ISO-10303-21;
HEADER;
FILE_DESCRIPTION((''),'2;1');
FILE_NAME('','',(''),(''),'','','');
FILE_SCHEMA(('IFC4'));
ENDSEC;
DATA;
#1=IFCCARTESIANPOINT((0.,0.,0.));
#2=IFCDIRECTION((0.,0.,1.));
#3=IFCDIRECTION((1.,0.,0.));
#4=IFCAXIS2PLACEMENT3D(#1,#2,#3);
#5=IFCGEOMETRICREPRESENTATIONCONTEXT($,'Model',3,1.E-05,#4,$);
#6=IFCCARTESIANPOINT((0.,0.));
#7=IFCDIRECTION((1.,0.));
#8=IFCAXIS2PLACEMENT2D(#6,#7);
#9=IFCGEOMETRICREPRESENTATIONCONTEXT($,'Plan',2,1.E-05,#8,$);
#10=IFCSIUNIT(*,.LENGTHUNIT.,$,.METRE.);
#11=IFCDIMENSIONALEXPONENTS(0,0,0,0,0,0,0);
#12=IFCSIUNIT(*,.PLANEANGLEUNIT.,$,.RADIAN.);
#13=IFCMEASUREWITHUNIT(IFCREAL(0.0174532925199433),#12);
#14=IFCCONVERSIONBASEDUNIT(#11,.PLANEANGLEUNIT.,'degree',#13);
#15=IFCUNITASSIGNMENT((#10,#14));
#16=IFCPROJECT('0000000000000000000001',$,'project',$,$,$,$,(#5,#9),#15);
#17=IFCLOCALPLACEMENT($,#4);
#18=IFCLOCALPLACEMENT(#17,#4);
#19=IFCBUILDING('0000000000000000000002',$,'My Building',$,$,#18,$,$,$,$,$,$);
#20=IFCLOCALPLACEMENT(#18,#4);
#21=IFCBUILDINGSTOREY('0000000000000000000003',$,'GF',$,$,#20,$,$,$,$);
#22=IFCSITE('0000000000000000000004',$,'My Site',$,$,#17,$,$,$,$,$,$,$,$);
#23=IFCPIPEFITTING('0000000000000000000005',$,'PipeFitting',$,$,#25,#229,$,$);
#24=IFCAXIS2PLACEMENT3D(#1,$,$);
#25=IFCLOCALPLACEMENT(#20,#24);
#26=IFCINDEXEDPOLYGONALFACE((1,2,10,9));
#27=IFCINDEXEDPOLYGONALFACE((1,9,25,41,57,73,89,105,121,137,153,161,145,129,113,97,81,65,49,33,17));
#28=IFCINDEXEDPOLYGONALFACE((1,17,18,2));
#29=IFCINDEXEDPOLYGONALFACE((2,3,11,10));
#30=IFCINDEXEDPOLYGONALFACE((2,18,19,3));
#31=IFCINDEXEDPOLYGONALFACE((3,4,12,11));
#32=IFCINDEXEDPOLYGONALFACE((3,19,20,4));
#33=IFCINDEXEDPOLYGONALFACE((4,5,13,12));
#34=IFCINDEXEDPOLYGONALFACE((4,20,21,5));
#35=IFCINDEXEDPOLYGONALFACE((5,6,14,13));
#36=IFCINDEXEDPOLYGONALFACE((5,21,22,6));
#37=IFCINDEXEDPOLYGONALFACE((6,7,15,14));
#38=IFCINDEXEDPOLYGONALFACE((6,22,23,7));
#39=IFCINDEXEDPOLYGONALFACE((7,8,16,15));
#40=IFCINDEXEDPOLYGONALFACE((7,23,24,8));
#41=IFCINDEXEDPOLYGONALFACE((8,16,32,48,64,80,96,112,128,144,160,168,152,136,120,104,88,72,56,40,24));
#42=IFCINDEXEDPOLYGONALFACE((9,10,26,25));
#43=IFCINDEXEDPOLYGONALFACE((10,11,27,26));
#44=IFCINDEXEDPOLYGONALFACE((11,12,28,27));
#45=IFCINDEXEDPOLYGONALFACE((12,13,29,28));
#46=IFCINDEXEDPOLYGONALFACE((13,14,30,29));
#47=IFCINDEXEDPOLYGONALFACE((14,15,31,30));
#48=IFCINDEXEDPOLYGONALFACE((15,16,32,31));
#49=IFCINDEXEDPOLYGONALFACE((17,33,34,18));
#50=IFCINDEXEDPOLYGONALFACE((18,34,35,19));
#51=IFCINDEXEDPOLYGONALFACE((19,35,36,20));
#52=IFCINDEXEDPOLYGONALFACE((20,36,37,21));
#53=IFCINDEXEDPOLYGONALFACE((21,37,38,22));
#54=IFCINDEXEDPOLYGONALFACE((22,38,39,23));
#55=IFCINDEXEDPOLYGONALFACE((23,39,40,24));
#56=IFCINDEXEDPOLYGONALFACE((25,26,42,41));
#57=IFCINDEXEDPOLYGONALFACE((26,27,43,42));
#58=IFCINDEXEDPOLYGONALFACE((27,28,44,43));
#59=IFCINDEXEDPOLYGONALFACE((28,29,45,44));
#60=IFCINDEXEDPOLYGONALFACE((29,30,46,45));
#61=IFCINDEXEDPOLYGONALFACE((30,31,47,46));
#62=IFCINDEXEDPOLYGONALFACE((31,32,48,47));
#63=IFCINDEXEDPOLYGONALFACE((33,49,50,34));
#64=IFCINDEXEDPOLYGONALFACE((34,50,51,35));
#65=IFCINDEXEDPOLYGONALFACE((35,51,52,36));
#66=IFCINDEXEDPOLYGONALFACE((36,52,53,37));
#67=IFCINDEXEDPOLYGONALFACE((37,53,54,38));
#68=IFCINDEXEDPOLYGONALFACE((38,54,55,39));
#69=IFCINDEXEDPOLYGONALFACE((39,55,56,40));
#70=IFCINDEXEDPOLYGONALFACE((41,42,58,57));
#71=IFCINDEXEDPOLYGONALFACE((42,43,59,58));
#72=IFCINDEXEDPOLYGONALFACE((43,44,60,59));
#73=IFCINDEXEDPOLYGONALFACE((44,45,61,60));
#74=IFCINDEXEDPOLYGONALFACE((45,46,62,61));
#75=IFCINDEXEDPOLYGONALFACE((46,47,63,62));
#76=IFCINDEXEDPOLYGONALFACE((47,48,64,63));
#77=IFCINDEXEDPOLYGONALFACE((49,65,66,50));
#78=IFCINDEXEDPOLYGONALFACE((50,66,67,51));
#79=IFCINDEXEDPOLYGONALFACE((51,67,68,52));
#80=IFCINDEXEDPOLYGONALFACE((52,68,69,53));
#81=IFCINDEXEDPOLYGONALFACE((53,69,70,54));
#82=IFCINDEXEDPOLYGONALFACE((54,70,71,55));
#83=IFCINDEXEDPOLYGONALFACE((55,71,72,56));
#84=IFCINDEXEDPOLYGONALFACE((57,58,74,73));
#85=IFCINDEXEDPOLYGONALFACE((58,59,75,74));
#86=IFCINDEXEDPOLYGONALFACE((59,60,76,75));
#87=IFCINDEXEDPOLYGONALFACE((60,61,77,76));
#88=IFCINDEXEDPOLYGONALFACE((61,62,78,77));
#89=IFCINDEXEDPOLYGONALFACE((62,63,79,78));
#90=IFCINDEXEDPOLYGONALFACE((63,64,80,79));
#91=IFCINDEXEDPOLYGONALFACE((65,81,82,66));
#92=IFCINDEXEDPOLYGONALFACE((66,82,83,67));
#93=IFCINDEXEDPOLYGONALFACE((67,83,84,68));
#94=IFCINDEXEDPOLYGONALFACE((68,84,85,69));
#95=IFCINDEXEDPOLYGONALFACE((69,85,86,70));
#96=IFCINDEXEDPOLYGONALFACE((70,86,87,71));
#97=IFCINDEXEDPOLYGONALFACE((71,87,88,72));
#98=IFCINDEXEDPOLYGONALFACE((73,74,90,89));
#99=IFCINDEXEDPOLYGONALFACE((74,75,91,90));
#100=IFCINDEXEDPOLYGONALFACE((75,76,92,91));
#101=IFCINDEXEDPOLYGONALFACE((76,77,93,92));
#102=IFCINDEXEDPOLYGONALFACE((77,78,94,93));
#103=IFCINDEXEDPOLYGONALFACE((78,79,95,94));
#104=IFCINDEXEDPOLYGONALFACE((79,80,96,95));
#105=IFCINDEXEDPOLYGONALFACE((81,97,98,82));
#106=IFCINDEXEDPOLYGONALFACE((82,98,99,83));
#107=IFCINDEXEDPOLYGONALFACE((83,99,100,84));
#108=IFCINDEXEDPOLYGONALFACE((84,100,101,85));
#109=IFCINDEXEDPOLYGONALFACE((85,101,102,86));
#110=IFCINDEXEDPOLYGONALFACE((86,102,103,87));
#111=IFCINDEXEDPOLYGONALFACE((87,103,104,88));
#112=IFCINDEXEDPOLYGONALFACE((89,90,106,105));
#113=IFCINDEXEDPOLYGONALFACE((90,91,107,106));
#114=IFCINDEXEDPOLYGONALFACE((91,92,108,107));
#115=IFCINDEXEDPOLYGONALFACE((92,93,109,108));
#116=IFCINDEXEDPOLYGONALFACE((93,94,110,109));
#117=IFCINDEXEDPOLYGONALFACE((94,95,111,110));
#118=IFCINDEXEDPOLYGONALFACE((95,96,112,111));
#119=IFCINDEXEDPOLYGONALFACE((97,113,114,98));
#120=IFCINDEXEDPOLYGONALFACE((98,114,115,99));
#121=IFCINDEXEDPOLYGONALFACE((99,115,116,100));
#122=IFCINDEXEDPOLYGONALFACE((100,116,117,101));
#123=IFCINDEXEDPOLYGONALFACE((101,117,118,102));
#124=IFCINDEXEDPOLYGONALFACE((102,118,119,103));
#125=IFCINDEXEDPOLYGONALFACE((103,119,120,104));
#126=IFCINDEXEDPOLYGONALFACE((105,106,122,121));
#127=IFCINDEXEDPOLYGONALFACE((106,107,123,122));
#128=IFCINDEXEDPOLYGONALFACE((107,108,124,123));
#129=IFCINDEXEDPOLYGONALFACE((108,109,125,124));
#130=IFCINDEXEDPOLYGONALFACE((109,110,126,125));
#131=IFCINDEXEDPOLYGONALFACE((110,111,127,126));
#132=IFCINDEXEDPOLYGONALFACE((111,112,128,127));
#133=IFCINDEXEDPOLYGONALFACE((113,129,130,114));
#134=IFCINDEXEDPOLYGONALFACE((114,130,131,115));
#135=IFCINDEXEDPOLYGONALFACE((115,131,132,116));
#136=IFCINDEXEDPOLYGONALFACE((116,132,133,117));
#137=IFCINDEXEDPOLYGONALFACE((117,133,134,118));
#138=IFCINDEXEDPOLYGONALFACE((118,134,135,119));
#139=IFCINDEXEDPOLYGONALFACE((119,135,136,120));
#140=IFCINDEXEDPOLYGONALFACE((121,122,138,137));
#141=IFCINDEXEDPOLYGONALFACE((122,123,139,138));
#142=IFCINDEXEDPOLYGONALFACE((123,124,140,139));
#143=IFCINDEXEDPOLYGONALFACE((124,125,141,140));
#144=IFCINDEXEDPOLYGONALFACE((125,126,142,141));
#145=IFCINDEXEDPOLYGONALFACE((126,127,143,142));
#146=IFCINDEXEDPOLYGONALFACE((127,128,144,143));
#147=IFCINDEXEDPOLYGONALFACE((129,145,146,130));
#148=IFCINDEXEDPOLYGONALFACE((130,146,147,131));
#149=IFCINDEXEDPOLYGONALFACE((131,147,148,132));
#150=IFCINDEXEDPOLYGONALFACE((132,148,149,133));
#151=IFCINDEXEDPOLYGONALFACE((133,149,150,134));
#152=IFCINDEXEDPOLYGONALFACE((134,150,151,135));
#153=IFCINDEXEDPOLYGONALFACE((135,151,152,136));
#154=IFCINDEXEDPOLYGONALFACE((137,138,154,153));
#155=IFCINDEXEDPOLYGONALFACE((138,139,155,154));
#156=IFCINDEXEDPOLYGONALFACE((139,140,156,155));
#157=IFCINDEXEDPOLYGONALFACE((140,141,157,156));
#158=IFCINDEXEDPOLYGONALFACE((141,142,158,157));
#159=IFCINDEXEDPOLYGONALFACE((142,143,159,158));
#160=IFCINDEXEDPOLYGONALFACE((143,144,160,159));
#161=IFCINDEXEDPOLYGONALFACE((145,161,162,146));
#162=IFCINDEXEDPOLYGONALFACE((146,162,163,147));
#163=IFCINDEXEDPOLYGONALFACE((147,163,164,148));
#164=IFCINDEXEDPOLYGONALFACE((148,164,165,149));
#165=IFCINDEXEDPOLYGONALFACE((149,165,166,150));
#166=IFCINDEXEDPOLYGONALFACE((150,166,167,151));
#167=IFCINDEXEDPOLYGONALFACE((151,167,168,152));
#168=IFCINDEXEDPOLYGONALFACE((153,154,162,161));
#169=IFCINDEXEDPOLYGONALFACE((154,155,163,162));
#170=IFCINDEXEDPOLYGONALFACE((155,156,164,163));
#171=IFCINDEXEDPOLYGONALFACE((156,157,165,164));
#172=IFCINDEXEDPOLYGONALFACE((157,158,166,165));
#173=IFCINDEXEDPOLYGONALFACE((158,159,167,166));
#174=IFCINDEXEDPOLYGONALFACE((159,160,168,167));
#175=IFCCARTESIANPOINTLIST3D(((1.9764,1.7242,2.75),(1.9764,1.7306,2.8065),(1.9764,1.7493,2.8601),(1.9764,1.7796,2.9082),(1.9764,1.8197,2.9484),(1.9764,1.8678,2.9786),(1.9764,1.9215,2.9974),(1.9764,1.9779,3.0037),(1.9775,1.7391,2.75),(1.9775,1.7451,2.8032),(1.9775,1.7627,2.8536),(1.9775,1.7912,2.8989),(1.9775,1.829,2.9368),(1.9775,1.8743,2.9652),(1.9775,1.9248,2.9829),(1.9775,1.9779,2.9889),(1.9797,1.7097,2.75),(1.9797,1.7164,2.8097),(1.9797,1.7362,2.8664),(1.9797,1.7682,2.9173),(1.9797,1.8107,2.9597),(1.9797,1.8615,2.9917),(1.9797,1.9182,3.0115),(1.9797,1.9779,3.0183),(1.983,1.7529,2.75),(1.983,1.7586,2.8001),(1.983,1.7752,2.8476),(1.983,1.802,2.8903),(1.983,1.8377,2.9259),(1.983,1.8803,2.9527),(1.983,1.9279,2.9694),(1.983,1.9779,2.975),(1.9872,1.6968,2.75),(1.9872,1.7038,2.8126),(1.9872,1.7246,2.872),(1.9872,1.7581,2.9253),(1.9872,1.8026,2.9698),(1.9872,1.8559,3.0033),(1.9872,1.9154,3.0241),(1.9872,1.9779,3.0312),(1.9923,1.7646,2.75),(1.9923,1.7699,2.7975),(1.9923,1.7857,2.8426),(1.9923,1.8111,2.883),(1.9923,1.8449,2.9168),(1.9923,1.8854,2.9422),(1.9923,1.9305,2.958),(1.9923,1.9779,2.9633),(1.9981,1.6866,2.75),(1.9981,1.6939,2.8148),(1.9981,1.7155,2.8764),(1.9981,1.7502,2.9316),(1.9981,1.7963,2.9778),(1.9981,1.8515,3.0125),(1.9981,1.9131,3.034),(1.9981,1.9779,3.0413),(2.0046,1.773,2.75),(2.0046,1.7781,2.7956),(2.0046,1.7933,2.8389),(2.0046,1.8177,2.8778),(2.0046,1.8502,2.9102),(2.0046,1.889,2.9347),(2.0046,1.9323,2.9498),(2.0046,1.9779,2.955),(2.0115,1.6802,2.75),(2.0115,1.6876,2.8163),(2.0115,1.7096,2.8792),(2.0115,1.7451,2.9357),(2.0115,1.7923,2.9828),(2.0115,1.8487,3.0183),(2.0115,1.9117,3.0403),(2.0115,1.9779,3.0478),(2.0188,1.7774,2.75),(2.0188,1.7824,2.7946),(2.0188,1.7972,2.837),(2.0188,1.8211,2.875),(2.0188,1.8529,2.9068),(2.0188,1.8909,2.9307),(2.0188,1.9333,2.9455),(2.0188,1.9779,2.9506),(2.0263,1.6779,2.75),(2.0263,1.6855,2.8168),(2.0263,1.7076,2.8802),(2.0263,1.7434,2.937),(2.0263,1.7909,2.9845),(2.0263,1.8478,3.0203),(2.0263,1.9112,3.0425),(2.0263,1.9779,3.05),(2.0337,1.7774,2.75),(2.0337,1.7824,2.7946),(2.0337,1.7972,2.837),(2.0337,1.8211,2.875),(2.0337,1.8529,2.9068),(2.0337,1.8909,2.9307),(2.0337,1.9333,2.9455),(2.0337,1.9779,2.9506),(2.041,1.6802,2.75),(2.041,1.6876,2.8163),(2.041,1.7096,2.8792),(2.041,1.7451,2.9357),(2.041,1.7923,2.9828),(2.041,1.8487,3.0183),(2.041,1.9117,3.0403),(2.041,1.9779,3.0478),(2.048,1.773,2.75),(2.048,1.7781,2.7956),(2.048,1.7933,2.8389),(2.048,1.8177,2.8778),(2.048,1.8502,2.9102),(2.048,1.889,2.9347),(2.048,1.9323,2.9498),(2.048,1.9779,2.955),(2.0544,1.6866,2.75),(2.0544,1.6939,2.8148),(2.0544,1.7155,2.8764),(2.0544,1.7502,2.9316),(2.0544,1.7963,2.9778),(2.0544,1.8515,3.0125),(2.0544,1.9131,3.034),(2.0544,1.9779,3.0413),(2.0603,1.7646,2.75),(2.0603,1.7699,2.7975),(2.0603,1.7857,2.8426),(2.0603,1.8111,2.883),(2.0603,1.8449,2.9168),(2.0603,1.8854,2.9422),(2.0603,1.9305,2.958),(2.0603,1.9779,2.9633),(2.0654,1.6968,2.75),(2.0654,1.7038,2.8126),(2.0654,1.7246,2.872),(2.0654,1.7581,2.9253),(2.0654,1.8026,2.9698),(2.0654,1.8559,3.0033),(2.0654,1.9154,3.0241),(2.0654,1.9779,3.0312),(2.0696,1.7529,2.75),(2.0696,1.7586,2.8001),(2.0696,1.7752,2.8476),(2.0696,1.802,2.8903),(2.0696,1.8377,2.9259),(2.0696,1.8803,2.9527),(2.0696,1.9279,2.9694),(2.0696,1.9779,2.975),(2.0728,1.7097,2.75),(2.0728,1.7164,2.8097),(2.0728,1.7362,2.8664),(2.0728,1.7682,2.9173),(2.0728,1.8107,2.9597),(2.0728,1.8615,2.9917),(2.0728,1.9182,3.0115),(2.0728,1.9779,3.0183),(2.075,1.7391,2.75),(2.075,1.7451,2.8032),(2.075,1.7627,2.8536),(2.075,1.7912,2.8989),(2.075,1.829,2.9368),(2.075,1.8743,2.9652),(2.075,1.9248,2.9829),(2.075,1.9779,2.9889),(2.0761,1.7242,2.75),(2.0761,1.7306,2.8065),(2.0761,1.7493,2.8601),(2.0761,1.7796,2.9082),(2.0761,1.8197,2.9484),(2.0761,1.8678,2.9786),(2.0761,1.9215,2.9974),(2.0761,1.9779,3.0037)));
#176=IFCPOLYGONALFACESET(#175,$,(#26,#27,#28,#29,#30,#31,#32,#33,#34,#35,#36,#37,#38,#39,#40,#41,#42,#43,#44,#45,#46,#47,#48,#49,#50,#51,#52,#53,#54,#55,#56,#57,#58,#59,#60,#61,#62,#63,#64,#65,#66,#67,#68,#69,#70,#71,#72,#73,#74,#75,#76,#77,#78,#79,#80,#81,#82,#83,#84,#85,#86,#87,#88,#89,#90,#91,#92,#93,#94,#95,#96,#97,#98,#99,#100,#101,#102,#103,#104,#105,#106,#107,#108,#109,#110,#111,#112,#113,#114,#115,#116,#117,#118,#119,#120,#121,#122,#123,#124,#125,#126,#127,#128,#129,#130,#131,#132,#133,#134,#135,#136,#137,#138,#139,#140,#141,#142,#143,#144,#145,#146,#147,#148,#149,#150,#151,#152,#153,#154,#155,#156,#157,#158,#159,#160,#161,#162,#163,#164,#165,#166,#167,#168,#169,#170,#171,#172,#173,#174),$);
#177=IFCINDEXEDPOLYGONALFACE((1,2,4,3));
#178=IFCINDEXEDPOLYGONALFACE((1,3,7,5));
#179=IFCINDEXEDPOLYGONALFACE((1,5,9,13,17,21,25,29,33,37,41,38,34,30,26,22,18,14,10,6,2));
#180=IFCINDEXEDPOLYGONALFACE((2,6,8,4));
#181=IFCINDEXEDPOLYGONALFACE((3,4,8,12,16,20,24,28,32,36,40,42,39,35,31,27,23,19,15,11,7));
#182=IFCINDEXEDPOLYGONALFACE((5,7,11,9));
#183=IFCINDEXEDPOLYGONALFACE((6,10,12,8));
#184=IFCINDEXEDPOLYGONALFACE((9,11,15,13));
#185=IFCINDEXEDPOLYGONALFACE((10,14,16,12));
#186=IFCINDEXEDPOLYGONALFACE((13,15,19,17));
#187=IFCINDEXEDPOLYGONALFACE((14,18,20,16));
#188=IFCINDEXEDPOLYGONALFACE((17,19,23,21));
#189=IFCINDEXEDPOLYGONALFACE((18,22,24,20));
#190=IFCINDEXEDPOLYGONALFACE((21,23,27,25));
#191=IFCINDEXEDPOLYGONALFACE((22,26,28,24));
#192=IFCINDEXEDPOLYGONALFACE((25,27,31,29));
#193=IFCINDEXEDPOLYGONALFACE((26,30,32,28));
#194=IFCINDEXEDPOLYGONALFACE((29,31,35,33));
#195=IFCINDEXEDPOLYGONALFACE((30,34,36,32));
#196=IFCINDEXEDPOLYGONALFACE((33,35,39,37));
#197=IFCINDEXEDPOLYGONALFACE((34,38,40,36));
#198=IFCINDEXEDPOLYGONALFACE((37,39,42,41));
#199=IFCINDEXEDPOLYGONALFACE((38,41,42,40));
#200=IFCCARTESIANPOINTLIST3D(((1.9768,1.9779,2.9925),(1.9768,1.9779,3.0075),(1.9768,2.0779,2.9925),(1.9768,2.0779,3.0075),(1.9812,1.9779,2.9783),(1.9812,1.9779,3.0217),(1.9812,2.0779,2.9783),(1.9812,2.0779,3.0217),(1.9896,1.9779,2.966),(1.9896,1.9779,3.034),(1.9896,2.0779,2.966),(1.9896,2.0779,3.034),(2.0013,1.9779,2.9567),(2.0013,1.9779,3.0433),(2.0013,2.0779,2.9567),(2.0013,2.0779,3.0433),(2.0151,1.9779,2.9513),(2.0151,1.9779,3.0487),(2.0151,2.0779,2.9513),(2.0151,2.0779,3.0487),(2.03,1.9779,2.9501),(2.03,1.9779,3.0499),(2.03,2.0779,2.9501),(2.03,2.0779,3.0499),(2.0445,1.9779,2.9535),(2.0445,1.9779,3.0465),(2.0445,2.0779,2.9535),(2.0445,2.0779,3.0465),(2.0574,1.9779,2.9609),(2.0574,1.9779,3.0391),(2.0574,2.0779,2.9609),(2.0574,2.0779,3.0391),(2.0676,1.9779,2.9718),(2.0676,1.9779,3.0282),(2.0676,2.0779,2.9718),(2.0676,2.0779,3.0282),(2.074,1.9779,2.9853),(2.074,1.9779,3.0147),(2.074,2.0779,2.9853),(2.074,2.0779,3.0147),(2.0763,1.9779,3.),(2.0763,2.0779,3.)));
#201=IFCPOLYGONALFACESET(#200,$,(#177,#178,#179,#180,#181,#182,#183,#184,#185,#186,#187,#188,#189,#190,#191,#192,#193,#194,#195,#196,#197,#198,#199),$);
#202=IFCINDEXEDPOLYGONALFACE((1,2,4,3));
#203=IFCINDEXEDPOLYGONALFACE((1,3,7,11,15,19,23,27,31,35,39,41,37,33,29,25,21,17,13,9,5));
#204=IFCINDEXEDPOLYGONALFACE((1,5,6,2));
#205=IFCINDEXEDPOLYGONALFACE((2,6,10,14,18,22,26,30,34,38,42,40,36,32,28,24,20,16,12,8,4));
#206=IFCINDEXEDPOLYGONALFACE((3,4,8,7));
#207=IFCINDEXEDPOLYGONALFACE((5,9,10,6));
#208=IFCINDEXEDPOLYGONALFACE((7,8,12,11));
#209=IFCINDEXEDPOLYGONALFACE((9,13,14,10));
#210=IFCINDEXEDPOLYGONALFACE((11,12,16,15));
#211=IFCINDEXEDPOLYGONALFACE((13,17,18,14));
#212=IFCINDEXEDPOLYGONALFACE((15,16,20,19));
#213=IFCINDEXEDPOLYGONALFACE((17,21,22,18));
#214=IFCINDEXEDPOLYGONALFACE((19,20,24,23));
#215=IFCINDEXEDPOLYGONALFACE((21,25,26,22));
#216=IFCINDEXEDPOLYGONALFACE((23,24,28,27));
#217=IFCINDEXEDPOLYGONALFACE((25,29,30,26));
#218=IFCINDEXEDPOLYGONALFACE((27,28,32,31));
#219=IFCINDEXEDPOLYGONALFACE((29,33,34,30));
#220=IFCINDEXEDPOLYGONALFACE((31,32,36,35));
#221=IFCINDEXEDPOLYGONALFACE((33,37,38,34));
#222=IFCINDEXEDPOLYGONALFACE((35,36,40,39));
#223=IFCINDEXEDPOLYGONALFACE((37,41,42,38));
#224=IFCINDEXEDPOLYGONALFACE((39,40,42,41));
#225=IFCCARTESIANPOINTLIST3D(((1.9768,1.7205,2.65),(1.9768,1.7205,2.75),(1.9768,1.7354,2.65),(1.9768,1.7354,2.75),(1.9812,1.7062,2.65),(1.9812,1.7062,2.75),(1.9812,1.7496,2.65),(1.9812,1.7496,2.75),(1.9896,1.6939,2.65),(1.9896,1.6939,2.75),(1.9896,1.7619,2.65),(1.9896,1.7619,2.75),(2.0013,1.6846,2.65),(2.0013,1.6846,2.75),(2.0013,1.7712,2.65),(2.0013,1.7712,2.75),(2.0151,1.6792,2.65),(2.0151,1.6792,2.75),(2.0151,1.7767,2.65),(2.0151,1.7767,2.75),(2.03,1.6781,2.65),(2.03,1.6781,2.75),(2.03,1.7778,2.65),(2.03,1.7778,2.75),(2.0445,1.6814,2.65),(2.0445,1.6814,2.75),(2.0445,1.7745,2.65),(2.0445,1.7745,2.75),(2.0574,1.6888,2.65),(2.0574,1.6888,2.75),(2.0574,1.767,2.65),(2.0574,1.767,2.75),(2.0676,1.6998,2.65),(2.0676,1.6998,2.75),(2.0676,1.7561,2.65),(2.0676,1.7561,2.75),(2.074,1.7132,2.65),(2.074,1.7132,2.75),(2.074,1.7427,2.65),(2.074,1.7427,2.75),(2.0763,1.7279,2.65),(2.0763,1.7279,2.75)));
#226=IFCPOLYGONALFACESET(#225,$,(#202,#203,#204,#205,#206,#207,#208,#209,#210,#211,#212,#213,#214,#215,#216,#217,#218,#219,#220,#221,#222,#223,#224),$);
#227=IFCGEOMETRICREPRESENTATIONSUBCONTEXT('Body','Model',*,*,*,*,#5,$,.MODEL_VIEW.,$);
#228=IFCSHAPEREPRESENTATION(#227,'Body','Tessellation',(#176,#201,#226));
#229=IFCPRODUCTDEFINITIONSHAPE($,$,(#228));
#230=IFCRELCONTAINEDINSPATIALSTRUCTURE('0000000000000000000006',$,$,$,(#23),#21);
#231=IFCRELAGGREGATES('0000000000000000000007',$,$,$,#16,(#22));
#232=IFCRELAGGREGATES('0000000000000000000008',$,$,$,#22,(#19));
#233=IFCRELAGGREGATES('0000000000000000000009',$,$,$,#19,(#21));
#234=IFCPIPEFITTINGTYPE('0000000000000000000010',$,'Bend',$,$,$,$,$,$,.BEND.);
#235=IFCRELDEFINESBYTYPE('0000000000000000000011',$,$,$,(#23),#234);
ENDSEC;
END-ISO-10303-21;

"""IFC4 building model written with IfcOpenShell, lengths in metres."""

from ifc_helpers import new_model, entity, si_unit, converted_unit, frame, origin_with_axes, origin_2d_with_axis, place, context, subcontext, project, spatial, circle, extrude, source, transform, mapped, type_object, type_shapes, element, save


model = new_model("IFC4")

# Units and contexts
model_context = context("Model", 3, precision=1e-05, world=origin_with_axes())
plan_context = context("Plan", 2, precision=1e-05, world=origin_2d_with_axis())
body_context_1 = subcontext(model_context, "Body", "Model", "MODEL_VIEW")
ifc_project = project(units=[si_unit("LENGTHUNIT", "METRE"), converted_unit("PLANEANGLEUNIT", "degree", entity("IfcReal", 0.0174532925199433), si_unit("PLANEANGLEUNIT", "RADIAN"), dimensions=[0, 0, 0, 0, 0, 0, 0])], contexts=[model_context, plan_context])

# Site, building, storey
site_placement = place(None, origin_with_axes())
site = spatial("IfcSite", under=ifc_project, at=site_placement, Name="My Site")
building_placement = place(site_placement, origin_with_axes())
building = spatial("IfcBuilding", under=site, at=building_placement, Name="My Building")
storey_placement = place(building_placement, origin_with_axes())
storey = spatial("IfcBuildingStorey", under=building, at=storey_placement, Name="GF")

# Pipe fitting
pipe_fitting_type = type_object("IfcPipeFittingType", Name="Bend", PredefinedType="BEND")
shared_shape_1 = source(origin_with_axes(), body_context_1, "Body", "SolidModel", [
    entity("IfcSweptDiskSolid", entity("IfcIndexedPolyCurve", entity("IfcCartesianPointList3D", [[0.0, 0.0, 0.1], [0.0, -0.0732, 0.2768], [0.0, -0.25, 0.35]]), [entity("IfcArcIndex", [1, 2, 3])]), 0.05),
    extrude(circle(Radius=0.05), origin_with_axes(), (0.0, 0.0, 1.0), 0.1),
    extrude(circle(Radius=0.05), frame((0.0, -0.25, 0.35), z_axis=(0.0, -1.0, 0.0), x_axis=(1.0, 0.0, 0.0)), (0.0, 0.0, 1.0), 0.1),
])
type_shapes(pipe_fitting_type, [shared_shape_1])
for number, where, z_axis, x_axis, name in (
    (1, (2.0263, 2.0779, 3.0), (0.0, -1.0, 0.0), (1.0, 0.0, 0.0), "PipeFitting"),
):
    element("IfcPipeFitting", number, at=place(storey_placement, frame(where, z_axis=z_axis, x_axis=x_axis)), inside=storey, type_object=pipe_fitting_type, Name=name, context=body_context_1, shape_type="MappedRepresentation", body=[
        mapped(shared_shape_1, transform((0.0, 0.0, 0.0), x_axis=(1.0, 0.0, 0.0), y_axis=(0.0, 1.0, 0.0), z_axis=(0.0, 0.0, 1.0), scale=1.0)),
    ])

save(model, "model.ifc")
